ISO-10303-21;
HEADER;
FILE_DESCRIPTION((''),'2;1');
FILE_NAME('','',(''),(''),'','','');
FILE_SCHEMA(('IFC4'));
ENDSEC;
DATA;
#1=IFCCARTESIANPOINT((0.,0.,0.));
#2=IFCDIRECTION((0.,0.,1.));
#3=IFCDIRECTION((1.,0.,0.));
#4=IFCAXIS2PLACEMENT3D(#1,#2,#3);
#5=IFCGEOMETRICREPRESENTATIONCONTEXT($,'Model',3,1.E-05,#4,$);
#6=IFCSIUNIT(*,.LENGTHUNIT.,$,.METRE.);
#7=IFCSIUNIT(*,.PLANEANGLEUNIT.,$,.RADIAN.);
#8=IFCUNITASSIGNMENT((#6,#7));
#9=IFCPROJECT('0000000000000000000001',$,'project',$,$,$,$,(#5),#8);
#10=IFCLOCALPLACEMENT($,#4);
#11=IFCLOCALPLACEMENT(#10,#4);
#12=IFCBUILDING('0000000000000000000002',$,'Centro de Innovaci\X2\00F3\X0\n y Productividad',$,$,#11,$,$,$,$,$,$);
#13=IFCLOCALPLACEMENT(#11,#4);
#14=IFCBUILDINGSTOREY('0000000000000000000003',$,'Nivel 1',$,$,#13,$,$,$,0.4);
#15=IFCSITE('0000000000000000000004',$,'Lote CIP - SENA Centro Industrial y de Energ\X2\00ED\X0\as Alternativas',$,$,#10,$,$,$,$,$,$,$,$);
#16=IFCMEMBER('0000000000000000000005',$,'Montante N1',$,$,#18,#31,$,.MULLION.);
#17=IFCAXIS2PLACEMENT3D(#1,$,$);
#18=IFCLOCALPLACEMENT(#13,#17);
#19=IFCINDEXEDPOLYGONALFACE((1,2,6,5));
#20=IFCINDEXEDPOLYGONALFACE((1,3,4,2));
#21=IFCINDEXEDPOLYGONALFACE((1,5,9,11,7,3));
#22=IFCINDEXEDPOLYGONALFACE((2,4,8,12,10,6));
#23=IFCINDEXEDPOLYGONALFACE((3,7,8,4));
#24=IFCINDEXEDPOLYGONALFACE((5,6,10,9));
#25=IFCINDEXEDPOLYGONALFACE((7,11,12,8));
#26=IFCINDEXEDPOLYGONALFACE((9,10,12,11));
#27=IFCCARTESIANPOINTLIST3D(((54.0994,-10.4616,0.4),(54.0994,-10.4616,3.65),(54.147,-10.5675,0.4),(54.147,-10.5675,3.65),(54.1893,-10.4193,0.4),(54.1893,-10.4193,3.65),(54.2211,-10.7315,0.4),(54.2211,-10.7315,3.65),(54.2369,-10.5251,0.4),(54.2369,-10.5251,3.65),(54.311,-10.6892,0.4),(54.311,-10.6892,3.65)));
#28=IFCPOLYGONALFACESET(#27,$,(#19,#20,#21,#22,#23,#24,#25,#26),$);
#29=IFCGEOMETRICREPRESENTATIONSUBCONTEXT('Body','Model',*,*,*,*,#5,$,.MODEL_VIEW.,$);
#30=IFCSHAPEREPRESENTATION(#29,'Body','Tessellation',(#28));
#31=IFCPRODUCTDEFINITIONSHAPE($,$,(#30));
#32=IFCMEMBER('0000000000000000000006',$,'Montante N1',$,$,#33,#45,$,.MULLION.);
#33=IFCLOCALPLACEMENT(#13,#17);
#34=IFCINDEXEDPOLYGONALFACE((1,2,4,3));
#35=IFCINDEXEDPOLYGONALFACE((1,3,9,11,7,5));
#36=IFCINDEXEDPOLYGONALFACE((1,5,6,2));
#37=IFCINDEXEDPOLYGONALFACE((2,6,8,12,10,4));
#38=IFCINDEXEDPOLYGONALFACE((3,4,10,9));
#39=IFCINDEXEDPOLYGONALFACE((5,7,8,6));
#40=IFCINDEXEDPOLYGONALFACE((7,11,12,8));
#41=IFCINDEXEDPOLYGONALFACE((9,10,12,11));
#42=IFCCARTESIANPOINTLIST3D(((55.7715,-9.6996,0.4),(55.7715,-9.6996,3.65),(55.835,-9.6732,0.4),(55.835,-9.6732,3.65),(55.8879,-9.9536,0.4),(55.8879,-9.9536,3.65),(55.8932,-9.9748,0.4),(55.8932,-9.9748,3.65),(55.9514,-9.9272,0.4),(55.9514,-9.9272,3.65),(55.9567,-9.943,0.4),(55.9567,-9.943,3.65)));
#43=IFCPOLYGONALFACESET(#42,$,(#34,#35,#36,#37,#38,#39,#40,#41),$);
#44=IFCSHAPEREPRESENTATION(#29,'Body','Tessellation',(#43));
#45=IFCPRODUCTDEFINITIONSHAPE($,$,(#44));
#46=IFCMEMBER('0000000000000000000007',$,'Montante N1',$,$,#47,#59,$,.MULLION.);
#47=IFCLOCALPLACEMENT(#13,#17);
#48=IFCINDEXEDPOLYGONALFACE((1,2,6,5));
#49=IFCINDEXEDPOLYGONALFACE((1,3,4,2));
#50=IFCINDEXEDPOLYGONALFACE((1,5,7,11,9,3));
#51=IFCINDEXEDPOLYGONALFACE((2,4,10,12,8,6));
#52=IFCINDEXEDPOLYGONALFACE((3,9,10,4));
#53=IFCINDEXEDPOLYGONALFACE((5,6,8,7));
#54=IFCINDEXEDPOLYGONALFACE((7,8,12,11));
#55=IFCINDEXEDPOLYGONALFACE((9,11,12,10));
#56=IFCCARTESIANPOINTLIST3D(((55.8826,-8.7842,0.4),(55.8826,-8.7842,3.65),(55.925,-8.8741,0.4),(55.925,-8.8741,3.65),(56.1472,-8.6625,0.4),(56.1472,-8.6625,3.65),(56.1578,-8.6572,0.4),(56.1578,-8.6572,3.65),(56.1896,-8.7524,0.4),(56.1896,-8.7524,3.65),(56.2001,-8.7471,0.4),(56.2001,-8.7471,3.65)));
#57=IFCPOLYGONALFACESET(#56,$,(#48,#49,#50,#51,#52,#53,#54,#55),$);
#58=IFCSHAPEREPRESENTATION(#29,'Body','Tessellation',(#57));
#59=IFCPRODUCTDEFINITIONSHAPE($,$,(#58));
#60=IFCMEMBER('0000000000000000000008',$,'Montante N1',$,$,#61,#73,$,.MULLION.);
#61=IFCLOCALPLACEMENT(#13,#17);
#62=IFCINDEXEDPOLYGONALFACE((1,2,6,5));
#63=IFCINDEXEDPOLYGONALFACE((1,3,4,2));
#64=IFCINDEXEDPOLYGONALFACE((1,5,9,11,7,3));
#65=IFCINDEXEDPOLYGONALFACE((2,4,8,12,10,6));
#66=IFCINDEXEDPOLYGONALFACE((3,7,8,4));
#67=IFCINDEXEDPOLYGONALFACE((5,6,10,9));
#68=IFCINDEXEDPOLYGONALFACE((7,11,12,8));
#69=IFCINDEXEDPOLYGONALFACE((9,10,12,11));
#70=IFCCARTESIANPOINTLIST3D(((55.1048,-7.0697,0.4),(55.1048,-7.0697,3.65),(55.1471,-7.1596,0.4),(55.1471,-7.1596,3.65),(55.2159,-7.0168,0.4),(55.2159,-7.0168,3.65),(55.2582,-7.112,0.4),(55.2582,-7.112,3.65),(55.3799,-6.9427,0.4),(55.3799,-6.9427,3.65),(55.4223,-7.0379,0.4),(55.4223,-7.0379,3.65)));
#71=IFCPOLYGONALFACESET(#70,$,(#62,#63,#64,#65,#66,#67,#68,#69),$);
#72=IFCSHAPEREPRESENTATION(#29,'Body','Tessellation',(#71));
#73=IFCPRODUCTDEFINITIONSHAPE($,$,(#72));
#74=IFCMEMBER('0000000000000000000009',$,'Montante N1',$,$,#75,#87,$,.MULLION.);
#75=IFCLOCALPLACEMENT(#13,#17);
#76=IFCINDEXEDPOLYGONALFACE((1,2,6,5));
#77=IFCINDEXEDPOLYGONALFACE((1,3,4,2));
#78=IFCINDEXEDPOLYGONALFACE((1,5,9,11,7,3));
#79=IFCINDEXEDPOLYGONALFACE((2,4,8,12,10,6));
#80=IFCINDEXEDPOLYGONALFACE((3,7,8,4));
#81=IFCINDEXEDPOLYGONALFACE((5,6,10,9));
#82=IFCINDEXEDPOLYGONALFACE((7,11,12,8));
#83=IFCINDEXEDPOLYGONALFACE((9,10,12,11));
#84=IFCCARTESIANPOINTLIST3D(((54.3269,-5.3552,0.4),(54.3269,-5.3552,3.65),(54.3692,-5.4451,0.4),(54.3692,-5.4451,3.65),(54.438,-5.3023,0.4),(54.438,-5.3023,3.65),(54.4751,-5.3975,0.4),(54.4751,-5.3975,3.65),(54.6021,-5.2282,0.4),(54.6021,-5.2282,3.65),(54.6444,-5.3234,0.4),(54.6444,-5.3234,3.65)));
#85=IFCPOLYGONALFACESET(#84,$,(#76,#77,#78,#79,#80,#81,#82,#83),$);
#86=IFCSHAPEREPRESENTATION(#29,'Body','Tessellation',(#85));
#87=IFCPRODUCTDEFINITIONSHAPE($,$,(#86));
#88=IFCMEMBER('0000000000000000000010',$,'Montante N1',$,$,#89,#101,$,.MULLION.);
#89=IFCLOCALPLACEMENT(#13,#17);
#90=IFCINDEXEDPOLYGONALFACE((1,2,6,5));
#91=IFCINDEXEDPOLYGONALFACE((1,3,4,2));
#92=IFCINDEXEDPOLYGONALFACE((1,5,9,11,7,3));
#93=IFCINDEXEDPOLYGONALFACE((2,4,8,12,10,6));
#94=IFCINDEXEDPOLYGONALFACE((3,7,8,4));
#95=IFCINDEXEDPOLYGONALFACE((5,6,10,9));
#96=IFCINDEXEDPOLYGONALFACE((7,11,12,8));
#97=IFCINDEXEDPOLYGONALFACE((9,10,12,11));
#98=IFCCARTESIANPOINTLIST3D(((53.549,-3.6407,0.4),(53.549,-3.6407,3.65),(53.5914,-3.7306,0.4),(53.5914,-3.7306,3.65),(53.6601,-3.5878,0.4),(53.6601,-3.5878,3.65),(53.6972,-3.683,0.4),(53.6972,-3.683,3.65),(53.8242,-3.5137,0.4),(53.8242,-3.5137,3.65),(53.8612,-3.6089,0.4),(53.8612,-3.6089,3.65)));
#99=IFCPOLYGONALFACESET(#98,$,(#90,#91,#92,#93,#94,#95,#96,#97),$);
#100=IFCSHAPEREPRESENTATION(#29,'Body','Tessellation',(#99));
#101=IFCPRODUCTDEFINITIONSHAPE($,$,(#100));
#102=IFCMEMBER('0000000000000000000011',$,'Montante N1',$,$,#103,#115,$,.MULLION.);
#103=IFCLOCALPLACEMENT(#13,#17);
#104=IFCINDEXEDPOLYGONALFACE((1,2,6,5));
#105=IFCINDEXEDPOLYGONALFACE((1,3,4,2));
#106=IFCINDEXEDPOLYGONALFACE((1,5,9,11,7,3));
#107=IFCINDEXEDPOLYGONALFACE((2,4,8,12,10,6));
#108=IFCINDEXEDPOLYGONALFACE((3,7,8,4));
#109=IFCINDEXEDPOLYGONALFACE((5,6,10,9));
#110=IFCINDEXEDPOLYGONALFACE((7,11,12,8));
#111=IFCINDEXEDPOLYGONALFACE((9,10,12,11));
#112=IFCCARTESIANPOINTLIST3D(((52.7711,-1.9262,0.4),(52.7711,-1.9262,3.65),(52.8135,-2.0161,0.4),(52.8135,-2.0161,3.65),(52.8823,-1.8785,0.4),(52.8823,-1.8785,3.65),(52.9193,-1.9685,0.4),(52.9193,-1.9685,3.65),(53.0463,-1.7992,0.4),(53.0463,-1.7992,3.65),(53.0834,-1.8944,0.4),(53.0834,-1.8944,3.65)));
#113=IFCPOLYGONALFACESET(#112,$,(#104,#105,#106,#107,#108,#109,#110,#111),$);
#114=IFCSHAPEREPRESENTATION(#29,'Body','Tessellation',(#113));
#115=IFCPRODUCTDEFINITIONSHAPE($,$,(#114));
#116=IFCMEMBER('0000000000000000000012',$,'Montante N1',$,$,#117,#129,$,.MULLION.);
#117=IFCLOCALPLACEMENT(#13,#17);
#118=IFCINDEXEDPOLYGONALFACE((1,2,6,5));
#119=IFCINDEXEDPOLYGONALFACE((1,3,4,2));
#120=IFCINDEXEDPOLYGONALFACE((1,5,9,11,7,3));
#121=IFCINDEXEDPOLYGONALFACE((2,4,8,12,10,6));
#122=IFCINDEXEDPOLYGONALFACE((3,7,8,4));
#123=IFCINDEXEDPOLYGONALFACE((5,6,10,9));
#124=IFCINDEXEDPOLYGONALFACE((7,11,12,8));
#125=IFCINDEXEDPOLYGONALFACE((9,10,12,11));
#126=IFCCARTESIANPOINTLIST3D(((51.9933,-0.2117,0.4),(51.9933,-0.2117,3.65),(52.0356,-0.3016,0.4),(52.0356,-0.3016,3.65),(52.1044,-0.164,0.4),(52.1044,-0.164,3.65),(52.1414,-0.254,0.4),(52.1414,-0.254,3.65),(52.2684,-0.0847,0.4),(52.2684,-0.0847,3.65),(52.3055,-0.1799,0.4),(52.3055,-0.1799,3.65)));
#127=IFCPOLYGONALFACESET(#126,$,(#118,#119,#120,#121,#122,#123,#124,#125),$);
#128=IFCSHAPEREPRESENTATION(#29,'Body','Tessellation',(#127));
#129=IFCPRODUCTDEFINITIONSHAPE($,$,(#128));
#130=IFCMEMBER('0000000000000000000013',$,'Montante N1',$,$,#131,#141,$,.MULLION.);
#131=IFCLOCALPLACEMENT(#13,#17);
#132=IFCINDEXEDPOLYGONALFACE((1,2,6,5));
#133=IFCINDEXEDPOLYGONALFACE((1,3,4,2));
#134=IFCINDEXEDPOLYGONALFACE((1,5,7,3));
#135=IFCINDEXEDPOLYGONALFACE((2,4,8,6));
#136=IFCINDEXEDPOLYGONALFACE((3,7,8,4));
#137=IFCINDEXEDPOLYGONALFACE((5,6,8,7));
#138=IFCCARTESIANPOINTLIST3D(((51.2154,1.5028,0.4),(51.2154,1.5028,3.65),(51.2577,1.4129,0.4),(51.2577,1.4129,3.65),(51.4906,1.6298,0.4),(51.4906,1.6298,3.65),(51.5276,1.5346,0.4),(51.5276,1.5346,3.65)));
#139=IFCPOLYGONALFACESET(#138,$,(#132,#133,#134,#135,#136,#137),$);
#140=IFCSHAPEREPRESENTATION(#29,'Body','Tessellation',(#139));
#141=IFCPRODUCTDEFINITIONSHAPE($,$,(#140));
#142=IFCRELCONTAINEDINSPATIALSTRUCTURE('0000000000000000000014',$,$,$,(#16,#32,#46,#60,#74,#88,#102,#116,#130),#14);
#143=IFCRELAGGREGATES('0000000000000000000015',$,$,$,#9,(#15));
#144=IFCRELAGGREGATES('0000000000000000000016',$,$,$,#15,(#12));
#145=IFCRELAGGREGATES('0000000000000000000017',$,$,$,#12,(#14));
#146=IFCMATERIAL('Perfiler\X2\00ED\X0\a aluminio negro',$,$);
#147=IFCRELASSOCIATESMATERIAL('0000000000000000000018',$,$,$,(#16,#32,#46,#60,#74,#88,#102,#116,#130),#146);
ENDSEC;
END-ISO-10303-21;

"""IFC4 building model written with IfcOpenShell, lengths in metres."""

from ifc_helpers import new_model, si_unit, frame, origin_with_axes, place, context, subcontext, project, spatial, polyline, outline, extrude, material, element, save


model = new_model("IFC4")

# Units and contexts
model_context = context("Model", 3, precision=1e-05, world=origin_with_axes())
body_context = subcontext(model_context, "Body", "Model", "MODEL_VIEW")
ifc_project = project(units=[si_unit("LENGTHUNIT", "METRE"), si_unit("PLANEANGLEUNIT", "RADIAN")], contexts=[model_context])

# Site, building, storey
site_placement = place(None, origin_with_axes())
site = spatial("IfcSite", under=ifc_project, at=site_placement, Name="Lote CIP - SENA Centro Industrial y de Energías Alternativas")
building_placement = place(site_placement, origin_with_axes())
building = spatial("IfcBuilding", under=site, at=building_placement, Name="Centro de Innovación y Productividad")
storey_placement = place(building_placement, origin_with_axes())
storey = spatial("IfcBuildingStorey", under=building, at=storey_placement, Name="Nivel 1", Elevation=0.4)

# Members
ifc_material = material(Name="Perfilería aluminio negro")
member_1_placement = place(storey_placement, origin_with_axes())
element("IfcMember", 1, at=member_1_placement, inside=storey, material=ifc_material, Name="Montante N1", PredefinedType="MULLION", context=body_context, shape_type="SweptSolid", body=[
    extrude(outline(polyline([(54.2211, -10.7315), (54.147, -10.5675), (54.0994, -10.4616), (54.1893, -10.4193), (54.2369, -10.5251), (54.311, -10.6892), (54.2211, -10.7315)])), frame((0.0, 0.0, 0.4)), (0.0, 0.0, 1.0), 3.25),
])
member_2_placement = place(storey_placement, origin_with_axes())
element("IfcMember", 2, at=member_2_placement, inside=storey, material=ifc_material, Name="Montante N1", PredefinedType="MULLION", context=body_context, shape_type="SweptSolid", body=[
    extrude(outline(polyline([(55.9514, -9.9272), (55.9567, -9.943), (55.8932, -9.9748), (55.8879, -9.9536), (55.7715, -9.6996), (55.835, -9.6732), (55.9514, -9.9272)])), frame((0.0, 0.0, 0.4)), (0.0, 0.0, 1.0), 3.25),
])
member_3_placement = place(storey_placement, origin_with_axes())
element("IfcMember", 3, at=member_3_placement, inside=storey, material=ifc_material, Name="Montante N1", PredefinedType="MULLION", context=body_context, shape_type="SweptSolid", body=[
    extrude(outline(polyline([(55.8826, -8.7842), (56.1472, -8.6625), (56.1578, -8.6572), (56.2001, -8.7471), (56.1896, -8.7524), (55.925, -8.8741), (55.8826, -8.7842)])), frame((0.0, 0.0, 0.4)), (0.0, 0.0, 1.0), 3.25),
])
member_4_placement = place(storey_placement, origin_with_axes())
element("IfcMember", 4, at=member_4_placement, inside=storey, material=ifc_material, Name="Montante N1", PredefinedType="MULLION", context=body_context, shape_type="SweptSolid", body=[
    extrude(outline(polyline([(55.2582, -7.112), (55.1471, -7.1596), (55.1048, -7.0697), (55.2159, -7.0168), (55.3799, -6.9427), (55.4223, -7.0379), (55.2582, -7.112)])), frame((0.0, 0.0, 0.4)), (0.0, 0.0, 1.0), 3.25),
])
member_5_placement = place(storey_placement, origin_with_axes())
element("IfcMember", 5, at=member_5_placement, inside=storey, material=ifc_material, Name="Montante N1", PredefinedType="MULLION", context=body_context, shape_type="SweptSolid", body=[
    extrude(outline(polyline([(54.6021, -5.2282), (54.6444, -5.3234), (54.4751, -5.3975), (54.3692, -5.4451), (54.3269, -5.3552), (54.438, -5.3023), (54.6021, -5.2282)])), frame((0.0, 0.0, 0.4)), (0.0, 0.0, 1.0), 3.25),
])
member_6_placement = place(storey_placement, origin_with_axes())
element("IfcMember", 6, at=member_6_placement, inside=storey, material=ifc_material, Name="Montante N1", PredefinedType="MULLION", context=body_context, shape_type="SweptSolid", body=[
    extrude(outline(polyline([(53.8242, -3.5137), (53.8612, -3.6089), (53.6972, -3.683), (53.5914, -3.7306), (53.549, -3.6407), (53.6601, -3.5878), (53.8242, -3.5137)])), frame((0.0, 0.0, 0.4)), (0.0, 0.0, 1.0), 3.25),
])
member_7_placement = place(storey_placement, origin_with_axes())
element("IfcMember", 7, at=member_7_placement, inside=storey, material=ifc_material, Name="Montante N1", PredefinedType="MULLION", context=body_context, shape_type="SweptSolid", body=[
    extrude(outline(polyline([(53.0463, -1.7992), (53.0834, -1.8944), (52.9193, -1.9685), (52.8135, -2.0161), (52.7711, -1.9262), (52.8823, -1.8785), (53.0463, -1.7992)])), frame((0.0, 0.0, 0.4)), (0.0, 0.0, 1.0), 3.25),
])
member_8_placement = place(storey_placement, origin_with_axes())
element("IfcMember", 8, at=member_8_placement, inside=storey, material=ifc_material, Name="Montante N1", PredefinedType="MULLION", context=body_context, shape_type="SweptSolid", body=[
    extrude(outline(polyline([(52.2684, -0.0847), (52.3055, -0.1799), (52.1414, -0.254), (52.0356, -0.3016), (51.9933, -0.2117), (52.1044, -0.164), (52.2684, -0.0847)])), frame((0.0, 0.0, 0.4)), (0.0, 0.0, 1.0), 3.25),
])
member_9_placement = place(storey_placement, origin_with_axes())
element("IfcMember", 9, at=member_9_placement, inside=storey, material=ifc_material, Name="Montante N1", PredefinedType="MULLION", context=body_context, shape_type="SweptSolid", body=[
    extrude(outline(polyline([(51.5276, 1.5346), (51.2577, 1.4129), (51.2154, 1.5028), (51.4906, 1.6298), (51.5276, 1.5346)])), frame((0.0, 0.0, 0.4)), (0.0, 0.0, 1.0), 3.25),
])

save(model, "model.ifc")
